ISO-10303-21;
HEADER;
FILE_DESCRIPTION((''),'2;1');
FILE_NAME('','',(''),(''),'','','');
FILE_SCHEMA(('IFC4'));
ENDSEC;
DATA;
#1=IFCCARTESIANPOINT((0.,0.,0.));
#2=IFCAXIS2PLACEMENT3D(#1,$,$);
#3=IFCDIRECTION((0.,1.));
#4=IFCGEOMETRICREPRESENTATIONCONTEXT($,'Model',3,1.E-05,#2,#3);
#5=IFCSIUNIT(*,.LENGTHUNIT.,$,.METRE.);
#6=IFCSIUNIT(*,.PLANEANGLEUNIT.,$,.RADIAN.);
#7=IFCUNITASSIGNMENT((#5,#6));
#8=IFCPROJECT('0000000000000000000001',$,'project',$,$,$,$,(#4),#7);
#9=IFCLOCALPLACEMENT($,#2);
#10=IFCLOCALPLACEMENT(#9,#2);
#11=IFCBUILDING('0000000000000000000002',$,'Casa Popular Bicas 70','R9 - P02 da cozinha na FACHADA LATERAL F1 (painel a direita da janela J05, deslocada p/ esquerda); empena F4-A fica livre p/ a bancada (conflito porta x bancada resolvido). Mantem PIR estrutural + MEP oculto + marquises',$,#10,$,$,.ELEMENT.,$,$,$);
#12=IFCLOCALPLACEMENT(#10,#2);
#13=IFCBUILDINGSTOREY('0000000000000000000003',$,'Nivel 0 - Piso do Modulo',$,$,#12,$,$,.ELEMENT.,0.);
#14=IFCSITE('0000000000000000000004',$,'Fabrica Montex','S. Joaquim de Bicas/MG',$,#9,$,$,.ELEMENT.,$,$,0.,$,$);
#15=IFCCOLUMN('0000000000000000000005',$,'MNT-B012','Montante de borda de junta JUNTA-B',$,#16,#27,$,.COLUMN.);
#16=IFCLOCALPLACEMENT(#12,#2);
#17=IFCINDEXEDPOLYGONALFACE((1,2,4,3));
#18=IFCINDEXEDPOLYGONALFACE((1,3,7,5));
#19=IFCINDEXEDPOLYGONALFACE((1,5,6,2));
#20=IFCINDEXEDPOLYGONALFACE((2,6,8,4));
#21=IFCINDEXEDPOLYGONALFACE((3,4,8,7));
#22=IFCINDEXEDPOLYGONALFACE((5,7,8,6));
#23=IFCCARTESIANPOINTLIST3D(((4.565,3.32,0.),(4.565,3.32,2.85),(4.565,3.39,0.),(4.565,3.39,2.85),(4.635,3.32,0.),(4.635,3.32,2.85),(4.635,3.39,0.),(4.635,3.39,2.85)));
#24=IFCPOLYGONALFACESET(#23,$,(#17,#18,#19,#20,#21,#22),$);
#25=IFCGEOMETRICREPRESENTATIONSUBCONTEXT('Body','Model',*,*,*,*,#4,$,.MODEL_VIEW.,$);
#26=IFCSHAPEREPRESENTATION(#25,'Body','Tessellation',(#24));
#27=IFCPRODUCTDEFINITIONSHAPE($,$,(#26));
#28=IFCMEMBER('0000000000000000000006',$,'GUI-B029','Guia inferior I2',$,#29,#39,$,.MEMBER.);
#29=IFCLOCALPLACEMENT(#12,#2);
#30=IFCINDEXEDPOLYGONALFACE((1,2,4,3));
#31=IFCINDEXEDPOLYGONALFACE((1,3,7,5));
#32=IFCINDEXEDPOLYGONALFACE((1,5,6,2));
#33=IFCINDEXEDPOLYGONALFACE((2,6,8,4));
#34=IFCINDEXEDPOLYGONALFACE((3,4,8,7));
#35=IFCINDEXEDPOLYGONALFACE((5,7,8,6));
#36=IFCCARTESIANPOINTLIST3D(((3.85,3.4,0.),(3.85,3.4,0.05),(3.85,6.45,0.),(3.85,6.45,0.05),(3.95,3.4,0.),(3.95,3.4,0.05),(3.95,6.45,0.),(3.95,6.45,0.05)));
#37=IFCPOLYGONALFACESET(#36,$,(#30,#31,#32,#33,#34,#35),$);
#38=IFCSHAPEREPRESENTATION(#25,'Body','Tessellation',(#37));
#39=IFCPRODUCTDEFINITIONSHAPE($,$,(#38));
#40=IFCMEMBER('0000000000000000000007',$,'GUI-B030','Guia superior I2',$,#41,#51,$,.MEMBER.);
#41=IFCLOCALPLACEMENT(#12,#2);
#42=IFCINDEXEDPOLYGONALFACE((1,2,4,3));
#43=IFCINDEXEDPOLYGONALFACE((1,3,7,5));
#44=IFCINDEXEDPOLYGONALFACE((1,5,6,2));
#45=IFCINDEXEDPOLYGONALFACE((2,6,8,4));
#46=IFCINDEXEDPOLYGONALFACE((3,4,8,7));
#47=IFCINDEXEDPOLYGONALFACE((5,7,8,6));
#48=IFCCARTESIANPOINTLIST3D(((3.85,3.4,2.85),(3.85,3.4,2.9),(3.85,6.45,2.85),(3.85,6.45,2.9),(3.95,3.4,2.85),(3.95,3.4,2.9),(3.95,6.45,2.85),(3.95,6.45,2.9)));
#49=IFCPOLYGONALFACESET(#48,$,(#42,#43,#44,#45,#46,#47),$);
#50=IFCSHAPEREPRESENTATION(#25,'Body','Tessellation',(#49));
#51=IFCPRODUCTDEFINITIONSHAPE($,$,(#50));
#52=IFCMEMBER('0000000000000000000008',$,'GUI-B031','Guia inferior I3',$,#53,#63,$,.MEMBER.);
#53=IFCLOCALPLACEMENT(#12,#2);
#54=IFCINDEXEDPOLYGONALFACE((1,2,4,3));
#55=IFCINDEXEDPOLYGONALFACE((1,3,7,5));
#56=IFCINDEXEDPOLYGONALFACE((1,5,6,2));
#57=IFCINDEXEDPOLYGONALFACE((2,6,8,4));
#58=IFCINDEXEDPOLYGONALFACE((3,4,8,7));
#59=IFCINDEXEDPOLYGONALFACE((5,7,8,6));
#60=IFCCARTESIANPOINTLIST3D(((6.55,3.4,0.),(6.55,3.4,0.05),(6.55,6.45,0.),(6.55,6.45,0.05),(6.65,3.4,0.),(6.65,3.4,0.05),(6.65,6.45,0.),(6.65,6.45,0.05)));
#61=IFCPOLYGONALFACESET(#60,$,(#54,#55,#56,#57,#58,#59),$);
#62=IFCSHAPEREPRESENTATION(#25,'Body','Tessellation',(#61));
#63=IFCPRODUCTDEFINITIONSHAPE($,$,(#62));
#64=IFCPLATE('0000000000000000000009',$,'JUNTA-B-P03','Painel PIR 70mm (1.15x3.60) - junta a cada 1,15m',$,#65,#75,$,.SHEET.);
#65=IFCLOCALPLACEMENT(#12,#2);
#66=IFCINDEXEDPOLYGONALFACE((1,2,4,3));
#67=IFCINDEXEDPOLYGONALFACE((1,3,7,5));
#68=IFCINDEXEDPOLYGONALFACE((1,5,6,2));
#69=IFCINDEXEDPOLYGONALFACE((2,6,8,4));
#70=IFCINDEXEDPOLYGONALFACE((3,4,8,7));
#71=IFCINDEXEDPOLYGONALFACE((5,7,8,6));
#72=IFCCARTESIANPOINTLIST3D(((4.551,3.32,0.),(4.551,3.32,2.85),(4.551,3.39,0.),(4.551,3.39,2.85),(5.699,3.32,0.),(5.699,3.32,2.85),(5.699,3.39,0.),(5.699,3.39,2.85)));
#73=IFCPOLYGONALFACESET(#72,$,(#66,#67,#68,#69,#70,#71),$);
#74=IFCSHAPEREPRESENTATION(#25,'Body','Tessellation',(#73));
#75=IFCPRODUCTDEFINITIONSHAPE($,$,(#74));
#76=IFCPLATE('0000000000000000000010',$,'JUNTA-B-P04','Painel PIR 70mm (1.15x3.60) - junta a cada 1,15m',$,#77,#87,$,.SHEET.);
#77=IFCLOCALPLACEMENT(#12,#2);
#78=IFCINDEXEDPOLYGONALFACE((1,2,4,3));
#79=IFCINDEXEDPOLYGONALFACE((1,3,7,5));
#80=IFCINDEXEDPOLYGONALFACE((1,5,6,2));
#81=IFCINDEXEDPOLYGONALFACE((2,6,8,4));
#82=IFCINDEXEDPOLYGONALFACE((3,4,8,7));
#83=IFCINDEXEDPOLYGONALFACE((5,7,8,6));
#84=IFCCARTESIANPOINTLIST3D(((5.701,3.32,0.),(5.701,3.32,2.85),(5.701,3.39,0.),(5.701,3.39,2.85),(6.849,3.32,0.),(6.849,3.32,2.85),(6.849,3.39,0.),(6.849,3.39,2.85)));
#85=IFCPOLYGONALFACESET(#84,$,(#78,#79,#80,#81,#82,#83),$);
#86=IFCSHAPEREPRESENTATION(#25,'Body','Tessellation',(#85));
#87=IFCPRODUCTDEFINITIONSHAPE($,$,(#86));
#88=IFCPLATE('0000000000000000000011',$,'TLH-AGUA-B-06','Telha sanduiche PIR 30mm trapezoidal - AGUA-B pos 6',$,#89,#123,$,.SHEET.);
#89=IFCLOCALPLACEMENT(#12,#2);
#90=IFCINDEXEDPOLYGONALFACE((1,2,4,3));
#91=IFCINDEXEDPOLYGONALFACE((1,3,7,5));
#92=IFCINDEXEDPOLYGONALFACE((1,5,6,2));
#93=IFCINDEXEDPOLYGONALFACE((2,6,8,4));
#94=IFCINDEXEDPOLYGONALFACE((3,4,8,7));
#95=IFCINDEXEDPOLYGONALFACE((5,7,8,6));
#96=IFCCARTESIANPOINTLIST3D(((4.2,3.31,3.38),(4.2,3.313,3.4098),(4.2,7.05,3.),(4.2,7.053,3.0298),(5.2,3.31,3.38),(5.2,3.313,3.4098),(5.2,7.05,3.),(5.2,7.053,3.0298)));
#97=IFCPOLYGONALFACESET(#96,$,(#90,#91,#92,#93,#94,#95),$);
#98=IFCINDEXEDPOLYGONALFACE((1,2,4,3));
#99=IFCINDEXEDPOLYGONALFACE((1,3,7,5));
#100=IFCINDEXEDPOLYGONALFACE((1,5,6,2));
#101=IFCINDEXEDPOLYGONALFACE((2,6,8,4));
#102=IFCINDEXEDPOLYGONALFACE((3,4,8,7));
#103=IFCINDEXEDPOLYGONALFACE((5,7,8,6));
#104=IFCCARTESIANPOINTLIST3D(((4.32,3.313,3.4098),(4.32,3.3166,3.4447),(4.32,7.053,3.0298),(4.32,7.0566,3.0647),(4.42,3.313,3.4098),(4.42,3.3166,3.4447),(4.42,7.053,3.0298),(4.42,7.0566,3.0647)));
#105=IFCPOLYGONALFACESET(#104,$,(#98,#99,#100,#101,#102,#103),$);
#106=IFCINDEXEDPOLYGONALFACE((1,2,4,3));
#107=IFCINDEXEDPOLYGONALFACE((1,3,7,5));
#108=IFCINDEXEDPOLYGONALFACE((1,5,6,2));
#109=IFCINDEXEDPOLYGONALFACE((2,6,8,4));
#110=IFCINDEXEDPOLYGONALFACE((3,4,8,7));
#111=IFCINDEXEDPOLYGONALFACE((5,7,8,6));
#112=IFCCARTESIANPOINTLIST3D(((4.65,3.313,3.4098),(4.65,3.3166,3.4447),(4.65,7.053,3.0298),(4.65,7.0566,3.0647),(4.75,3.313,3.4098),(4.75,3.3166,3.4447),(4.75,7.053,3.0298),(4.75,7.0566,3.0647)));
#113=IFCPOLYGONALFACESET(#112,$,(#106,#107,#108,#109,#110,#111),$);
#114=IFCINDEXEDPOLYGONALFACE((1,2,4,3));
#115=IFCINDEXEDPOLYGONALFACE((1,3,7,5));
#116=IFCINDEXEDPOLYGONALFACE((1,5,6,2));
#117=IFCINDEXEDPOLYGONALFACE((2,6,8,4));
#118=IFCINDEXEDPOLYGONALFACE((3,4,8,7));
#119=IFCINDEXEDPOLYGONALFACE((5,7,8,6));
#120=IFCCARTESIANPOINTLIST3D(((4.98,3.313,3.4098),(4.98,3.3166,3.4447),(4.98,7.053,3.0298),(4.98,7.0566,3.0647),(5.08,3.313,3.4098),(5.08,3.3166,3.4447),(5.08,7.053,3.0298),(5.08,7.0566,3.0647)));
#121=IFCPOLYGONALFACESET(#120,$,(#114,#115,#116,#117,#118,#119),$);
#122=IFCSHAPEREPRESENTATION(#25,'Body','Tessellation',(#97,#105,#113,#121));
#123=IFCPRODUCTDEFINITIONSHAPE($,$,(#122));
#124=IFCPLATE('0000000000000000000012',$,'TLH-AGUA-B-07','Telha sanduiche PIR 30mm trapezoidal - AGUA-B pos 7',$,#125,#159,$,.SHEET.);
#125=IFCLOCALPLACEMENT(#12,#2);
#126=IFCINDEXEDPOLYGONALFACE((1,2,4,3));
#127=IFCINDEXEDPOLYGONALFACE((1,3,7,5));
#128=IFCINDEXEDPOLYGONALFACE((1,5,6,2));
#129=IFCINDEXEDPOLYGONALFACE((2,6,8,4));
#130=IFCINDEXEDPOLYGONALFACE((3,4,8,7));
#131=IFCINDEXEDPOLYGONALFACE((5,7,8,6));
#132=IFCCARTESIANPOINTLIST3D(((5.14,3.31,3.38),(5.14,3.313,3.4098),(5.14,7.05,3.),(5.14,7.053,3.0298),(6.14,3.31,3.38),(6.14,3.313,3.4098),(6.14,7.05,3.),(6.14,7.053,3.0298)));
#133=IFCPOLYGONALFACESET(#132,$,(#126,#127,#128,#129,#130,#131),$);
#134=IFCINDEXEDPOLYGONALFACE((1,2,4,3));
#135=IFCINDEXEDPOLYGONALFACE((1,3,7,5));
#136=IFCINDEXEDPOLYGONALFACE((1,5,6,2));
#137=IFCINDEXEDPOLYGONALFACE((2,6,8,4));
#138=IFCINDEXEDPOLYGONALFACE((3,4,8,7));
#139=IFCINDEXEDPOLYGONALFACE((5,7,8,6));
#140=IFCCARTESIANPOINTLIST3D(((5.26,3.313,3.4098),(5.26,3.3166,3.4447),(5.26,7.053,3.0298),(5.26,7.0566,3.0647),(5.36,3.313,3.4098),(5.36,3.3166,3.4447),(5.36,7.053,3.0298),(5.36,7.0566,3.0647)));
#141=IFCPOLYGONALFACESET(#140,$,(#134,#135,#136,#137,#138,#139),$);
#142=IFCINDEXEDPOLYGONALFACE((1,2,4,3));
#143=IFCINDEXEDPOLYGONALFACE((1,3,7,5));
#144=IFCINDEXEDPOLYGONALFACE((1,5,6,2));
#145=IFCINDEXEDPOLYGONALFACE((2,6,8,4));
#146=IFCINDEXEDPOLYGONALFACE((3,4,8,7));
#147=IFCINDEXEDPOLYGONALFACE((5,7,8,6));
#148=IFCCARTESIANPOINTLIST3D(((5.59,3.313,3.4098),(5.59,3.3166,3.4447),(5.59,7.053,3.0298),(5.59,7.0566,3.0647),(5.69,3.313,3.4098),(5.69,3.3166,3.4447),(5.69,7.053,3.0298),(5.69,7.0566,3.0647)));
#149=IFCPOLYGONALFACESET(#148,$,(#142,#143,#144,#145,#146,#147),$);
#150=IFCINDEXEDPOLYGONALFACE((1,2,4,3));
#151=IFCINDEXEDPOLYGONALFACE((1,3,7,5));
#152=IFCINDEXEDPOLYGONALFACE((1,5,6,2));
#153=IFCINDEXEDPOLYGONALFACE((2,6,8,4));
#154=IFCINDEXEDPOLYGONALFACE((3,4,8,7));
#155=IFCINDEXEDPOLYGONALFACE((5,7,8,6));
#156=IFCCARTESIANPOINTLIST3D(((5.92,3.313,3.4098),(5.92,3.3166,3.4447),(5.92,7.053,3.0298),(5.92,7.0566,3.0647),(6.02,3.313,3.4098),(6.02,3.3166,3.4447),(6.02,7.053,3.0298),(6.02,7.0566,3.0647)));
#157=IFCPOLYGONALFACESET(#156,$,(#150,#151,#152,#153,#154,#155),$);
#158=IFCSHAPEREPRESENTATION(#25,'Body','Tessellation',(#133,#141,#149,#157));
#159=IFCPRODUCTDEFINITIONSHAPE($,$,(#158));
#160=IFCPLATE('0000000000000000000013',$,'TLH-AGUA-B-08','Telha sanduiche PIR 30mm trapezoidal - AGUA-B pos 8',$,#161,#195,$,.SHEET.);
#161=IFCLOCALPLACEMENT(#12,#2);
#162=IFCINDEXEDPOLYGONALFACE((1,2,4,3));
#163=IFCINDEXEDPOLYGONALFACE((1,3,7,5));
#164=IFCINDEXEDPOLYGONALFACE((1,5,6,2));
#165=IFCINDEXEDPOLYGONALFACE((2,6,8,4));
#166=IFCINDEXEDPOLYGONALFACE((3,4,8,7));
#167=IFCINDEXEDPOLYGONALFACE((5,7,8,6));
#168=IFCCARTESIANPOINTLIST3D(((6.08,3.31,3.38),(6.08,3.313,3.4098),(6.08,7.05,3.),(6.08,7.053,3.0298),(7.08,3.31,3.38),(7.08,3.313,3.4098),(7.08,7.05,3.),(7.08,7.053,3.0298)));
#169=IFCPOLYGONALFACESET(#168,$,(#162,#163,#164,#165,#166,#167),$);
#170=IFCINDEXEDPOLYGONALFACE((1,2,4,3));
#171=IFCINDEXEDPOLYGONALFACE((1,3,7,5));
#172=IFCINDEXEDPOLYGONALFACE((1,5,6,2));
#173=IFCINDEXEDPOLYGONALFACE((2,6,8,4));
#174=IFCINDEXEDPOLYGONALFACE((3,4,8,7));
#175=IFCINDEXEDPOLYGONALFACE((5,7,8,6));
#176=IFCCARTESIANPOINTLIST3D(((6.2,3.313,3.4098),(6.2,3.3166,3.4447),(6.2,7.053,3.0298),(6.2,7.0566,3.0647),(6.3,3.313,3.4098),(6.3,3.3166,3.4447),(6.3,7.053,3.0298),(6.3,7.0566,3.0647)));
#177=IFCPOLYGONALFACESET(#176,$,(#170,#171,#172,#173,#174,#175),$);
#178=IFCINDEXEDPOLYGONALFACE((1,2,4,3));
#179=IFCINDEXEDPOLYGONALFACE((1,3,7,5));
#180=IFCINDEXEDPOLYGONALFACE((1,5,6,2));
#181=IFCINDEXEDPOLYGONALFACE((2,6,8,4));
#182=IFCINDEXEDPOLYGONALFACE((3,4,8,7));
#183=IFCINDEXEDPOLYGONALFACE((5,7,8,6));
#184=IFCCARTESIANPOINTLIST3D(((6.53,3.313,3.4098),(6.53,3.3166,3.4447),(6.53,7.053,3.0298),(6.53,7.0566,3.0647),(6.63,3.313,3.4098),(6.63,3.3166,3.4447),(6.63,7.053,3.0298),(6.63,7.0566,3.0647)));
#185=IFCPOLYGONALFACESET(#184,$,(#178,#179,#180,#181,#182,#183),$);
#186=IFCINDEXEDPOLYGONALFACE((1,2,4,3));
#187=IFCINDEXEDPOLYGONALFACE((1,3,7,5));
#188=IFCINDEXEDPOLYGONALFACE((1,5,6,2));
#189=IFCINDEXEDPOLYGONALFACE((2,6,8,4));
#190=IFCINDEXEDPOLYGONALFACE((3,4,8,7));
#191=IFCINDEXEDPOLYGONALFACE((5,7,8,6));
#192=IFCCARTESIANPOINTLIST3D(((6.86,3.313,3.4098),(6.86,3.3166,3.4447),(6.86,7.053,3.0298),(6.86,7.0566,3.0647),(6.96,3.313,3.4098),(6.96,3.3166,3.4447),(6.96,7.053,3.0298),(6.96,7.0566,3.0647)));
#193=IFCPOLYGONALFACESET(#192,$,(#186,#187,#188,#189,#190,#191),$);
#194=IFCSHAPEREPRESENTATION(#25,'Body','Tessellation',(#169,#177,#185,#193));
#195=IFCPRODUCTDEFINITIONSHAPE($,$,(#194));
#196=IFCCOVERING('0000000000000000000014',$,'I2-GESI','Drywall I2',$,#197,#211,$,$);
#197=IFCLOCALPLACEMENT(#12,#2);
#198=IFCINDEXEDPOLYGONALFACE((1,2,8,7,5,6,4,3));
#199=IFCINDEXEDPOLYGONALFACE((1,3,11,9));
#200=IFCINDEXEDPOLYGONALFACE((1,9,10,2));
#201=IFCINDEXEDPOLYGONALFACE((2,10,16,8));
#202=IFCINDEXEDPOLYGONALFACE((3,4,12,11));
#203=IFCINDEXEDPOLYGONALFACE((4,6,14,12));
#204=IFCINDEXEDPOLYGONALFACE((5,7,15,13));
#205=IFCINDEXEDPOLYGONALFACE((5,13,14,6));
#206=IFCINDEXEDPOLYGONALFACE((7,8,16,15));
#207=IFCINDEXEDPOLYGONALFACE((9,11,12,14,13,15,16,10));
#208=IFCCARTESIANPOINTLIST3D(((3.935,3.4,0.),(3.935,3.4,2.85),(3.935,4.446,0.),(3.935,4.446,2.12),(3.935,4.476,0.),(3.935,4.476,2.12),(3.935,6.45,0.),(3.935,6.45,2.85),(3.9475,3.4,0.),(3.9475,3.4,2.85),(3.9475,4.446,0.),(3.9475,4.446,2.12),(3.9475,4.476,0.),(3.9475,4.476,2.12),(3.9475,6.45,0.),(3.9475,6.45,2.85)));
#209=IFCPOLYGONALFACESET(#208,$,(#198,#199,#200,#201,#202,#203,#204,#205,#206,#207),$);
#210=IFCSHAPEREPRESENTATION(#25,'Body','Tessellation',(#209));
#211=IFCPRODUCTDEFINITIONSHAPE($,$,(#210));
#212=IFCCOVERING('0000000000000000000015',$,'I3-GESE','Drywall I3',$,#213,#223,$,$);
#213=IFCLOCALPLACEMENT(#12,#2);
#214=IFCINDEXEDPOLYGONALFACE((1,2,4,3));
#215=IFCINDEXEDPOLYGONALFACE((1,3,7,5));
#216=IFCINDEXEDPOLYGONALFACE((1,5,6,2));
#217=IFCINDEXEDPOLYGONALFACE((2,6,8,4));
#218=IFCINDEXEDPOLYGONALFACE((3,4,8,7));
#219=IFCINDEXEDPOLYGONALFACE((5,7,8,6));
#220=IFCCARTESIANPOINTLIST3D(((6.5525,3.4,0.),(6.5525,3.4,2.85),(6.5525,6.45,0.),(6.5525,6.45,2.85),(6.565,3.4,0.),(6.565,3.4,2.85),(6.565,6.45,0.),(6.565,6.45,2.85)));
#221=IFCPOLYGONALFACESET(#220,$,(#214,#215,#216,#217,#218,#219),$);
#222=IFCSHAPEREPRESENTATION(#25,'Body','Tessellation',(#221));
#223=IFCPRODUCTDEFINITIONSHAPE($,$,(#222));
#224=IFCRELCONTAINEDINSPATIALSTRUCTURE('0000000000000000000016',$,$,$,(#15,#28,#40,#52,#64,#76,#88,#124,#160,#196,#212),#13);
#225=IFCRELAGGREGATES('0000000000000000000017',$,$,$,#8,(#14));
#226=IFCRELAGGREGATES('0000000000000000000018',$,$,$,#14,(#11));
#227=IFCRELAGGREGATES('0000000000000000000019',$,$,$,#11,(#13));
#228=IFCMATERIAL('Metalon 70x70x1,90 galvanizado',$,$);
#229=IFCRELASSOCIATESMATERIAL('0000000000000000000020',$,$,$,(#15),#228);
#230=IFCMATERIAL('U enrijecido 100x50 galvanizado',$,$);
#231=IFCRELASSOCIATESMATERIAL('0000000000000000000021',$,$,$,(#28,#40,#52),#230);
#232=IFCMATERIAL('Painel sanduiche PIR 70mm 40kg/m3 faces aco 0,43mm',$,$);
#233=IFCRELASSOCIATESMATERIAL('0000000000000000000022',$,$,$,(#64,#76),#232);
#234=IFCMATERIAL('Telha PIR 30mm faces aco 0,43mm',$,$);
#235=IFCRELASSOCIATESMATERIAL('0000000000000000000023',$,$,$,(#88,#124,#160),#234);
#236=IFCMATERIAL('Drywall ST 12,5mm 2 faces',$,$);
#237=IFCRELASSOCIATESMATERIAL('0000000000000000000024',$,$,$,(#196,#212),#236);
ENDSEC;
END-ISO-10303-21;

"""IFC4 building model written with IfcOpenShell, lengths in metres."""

from ifc_helpers import new_model, si_unit, direction, frame, frame_2d, origin, origin_2d, place, context, subcontext, project, spatial, rectangle, extrude, material, element, save


model = new_model("IFC4")

# Units and contexts
model_context = context("Model", 3, precision=1e-05, world=origin(), true_north=direction((0.0, 1.0)))
body_context = subcontext(model_context, "Body", "Model", "MODEL_VIEW")
ifc_project = project(units=[si_unit("LENGTHUNIT", "METRE"), si_unit("PLANEANGLEUNIT", "RADIAN")], contexts=[model_context])

# Site, building, storey
site_placement = place(None, origin())
site = spatial("IfcSite", under=ifc_project, at=site_placement, Name="Fabrica Montex", Description="S. Joaquim de Bicas/MG", CompositionType="ELEMENT", RefElevation=0.0)
building_placement = place(site_placement, origin())
building = spatial("IfcBuilding", under=site, at=building_placement, Name="Casa Popular Bicas 70", Description="R9 - P02 da cozinha na FACHADA LATERAL F1 (painel a direita da janela J05, deslocada p/ esquerda); empena F4-A fica livre p/ a bancada (conflito porta x bancada resolvido). Mantem PIR estrutural + MEP oculto + marquises", CompositionType="ELEMENT")
storey_placement = place(building_placement, origin())
storey = spatial("IfcBuildingStorey", under=building, at=storey_placement, Name="Nivel 0 - Piso do Modulo", CompositionType="ELEMENT", Elevation=0.0)

# Column
ifc_material_1 = material(Name="Metalon 70x70x1,90 galvanizado")
column_placement = place(storey_placement, frame((4.6, 3.355, 0.0)))
element("IfcColumn", 1, at=column_placement, inside=storey, material=ifc_material_1, Name="MNT-B012", Description="Montante de borda de junta JUNTA-B", PredefinedType="COLUMN", context=body_context, shape_type="SweptSolid", body=[
    extrude(rectangle(XDim=0.07, YDim=0.07, at=origin_2d()), origin(), (0.0, 0.0, 1.0), 2.85),
])

# Members
ifc_material_2 = material(Name="U enrijecido 100x50 galvanizado")
for number, where, z_axis, x_axis, name, description in (
    (2, (3.9, 3.4, 0.025), (0.0, 1.0, 0.0), (0.0, 0.0, 1.0), "GUI-B029", "Guia inferior I2"),
    (3, (3.9, 3.4, 2.875), (0.0, 1.0, 0.0), (0.0, 0.0, 1.0), "GUI-B030", "Guia superior I2"),
    (4, (6.6, 3.4, 0.025), (0.0, 1.0, 0.0), (0.0, 0.0, 1.0), "GUI-B031", "Guia inferior I3"),
):
    element("IfcMember", number, at=place(storey_placement, frame(where, z_axis=z_axis, x_axis=x_axis)), inside=storey, material=ifc_material_2, Name=name, Description=description, PredefinedType="MEMBER", context=body_context, shape_type="SweptSolid", body=[
        extrude(rectangle(XDim=0.05, YDim=0.1, at=origin_2d()), origin(), (0.0, 0.0, 1.0), 3.05),
    ])

# Plates
ifc_material_3 = material(Name="Painel sanduiche PIR 70mm 40kg/m3 faces aco 0,43mm")
for number, where, x_axis, name in (
    (5, (4.551, 3.355, 0.0), (1.0, 0.0, 0.0), "JUNTA-B-P03"),
    (6, (5.701, 3.355, 0.0), (1.0, 0.0, 0.0), "JUNTA-B-P04"),
):
    element("IfcPlate", number, at=place(storey_placement, frame(where, x_axis=x_axis)), inside=storey, material=ifc_material_3, Name=name, Description="Painel PIR 70mm (1.15x3.60) - junta a cada 1,15m", PredefinedType="SHEET", context=body_context, shape_type="SweptSolid", body=[
        extrude(rectangle(XDim=1.148, YDim=0.07, at=frame_2d((0.574, 0.0))), origin(), (0.0, 0.0, 1.0), 2.85),
    ])
ifc_material_4 = material(Name="Telha PIR 30mm faces aco 0,43mm")
for number, where, z_axis, x_axis, name, description in (
    (7, (4.2, 3.31, 3.38), (0.0, 0.101084, 0.994878), (1.0, 0.0, 0.0), "TLH-AGUA-B-06", "Telha sanduiche PIR 30mm trapezoidal - AGUA-B pos 6"),
    (8, (5.14, 3.31, 3.38), (0.0, 0.101084, 0.994878), (1.0, 0.0, 0.0), "TLH-AGUA-B-07", "Telha sanduiche PIR 30mm trapezoidal - AGUA-B pos 7"),
    (9, (6.08, 3.31, 3.38), (0.0, 0.101084, 0.994878), (1.0, 0.0, 0.0), "TLH-AGUA-B-08", "Telha sanduiche PIR 30mm trapezoidal - AGUA-B pos 8"),
):
    element("IfcPlate", number, at=place(storey_placement, frame(where, z_axis=z_axis, x_axis=x_axis)), inside=storey, material=ifc_material_4, Name=name, Description=description, PredefinedType="SHEET", context=body_context, shape_type="SweptSolid", body=[
        extrude(rectangle(XDim=1.0, YDim=3.7593, at=frame_2d((0.5, 1.8796))), origin(), (0.0, 0.0, 1.0), 0.03),
        extrude(rectangle(XDim=0.1, YDim=3.7593, at=frame_2d((0.17, 1.8796))), frame((0.0, 0.0, 0.03)), (0.0, 0.0, 1.0), 0.035),
        extrude(rectangle(XDim=0.1, YDim=3.7593, at=frame_2d((0.5, 1.8796))), frame((0.0, 0.0, 0.03)), (0.0, 0.0, 1.0), 0.035),
        extrude(rectangle(XDim=0.1, YDim=3.7593, at=frame_2d((0.83, 1.8796))), frame((0.0, 0.0, 0.03)), (0.0, 0.0, 1.0), 0.035),
    ])

# Covering, opening
ifc_material_5 = material(Name="Drywall ST 12,5mm 2 faces")
covering_1_placement = place(storey_placement, frame((3.9412, 3.4, 0.0), x_axis=(0.0, 1.0, 0.0)))
covering_1 = element("IfcCovering", 10, at=covering_1_placement, inside=storey, material=ifc_material_5, Name="I2-GESI", Description="Drywall I2", context=body_context, shape_type="SweptSolid", body=[
    extrude(rectangle(XDim=3.05, YDim=0.0125, at=frame_2d((1.525, 0.0))), origin(), (0.0, 0.0, 1.0), 2.85),
])
opening_1_placement = place(storey_placement, frame((3.925, 4.461, 0.0)))
element("IfcOpeningElement", 11, at=opening_1_placement, cuts=covering_1, PredefinedType="OPENING", context=body_context, shape_type="SweptSolid", body=[
    extrude(rectangle(XDim=0.82, YDim=0.03, at=frame_2d((0.4, 0.0))), origin(), (0.0, 0.0, 1.0), 2.12),
])

# Covering
covering_2_placement = place(storey_placement, frame((6.5587, 3.4, 0.0), x_axis=(0.0, 1.0, 0.0)))
element("IfcCovering", 12, at=covering_2_placement, inside=storey, material=ifc_material_5, Name="I3-GESE", Description="Drywall I3", context=body_context, shape_type="SweptSolid", body=[
    extrude(rectangle(XDim=3.05, YDim=0.0125, at=frame_2d((1.525, 0.0))), origin(), (0.0, 0.0, 1.0), 2.85),
])

save(model, "model.ifc")
